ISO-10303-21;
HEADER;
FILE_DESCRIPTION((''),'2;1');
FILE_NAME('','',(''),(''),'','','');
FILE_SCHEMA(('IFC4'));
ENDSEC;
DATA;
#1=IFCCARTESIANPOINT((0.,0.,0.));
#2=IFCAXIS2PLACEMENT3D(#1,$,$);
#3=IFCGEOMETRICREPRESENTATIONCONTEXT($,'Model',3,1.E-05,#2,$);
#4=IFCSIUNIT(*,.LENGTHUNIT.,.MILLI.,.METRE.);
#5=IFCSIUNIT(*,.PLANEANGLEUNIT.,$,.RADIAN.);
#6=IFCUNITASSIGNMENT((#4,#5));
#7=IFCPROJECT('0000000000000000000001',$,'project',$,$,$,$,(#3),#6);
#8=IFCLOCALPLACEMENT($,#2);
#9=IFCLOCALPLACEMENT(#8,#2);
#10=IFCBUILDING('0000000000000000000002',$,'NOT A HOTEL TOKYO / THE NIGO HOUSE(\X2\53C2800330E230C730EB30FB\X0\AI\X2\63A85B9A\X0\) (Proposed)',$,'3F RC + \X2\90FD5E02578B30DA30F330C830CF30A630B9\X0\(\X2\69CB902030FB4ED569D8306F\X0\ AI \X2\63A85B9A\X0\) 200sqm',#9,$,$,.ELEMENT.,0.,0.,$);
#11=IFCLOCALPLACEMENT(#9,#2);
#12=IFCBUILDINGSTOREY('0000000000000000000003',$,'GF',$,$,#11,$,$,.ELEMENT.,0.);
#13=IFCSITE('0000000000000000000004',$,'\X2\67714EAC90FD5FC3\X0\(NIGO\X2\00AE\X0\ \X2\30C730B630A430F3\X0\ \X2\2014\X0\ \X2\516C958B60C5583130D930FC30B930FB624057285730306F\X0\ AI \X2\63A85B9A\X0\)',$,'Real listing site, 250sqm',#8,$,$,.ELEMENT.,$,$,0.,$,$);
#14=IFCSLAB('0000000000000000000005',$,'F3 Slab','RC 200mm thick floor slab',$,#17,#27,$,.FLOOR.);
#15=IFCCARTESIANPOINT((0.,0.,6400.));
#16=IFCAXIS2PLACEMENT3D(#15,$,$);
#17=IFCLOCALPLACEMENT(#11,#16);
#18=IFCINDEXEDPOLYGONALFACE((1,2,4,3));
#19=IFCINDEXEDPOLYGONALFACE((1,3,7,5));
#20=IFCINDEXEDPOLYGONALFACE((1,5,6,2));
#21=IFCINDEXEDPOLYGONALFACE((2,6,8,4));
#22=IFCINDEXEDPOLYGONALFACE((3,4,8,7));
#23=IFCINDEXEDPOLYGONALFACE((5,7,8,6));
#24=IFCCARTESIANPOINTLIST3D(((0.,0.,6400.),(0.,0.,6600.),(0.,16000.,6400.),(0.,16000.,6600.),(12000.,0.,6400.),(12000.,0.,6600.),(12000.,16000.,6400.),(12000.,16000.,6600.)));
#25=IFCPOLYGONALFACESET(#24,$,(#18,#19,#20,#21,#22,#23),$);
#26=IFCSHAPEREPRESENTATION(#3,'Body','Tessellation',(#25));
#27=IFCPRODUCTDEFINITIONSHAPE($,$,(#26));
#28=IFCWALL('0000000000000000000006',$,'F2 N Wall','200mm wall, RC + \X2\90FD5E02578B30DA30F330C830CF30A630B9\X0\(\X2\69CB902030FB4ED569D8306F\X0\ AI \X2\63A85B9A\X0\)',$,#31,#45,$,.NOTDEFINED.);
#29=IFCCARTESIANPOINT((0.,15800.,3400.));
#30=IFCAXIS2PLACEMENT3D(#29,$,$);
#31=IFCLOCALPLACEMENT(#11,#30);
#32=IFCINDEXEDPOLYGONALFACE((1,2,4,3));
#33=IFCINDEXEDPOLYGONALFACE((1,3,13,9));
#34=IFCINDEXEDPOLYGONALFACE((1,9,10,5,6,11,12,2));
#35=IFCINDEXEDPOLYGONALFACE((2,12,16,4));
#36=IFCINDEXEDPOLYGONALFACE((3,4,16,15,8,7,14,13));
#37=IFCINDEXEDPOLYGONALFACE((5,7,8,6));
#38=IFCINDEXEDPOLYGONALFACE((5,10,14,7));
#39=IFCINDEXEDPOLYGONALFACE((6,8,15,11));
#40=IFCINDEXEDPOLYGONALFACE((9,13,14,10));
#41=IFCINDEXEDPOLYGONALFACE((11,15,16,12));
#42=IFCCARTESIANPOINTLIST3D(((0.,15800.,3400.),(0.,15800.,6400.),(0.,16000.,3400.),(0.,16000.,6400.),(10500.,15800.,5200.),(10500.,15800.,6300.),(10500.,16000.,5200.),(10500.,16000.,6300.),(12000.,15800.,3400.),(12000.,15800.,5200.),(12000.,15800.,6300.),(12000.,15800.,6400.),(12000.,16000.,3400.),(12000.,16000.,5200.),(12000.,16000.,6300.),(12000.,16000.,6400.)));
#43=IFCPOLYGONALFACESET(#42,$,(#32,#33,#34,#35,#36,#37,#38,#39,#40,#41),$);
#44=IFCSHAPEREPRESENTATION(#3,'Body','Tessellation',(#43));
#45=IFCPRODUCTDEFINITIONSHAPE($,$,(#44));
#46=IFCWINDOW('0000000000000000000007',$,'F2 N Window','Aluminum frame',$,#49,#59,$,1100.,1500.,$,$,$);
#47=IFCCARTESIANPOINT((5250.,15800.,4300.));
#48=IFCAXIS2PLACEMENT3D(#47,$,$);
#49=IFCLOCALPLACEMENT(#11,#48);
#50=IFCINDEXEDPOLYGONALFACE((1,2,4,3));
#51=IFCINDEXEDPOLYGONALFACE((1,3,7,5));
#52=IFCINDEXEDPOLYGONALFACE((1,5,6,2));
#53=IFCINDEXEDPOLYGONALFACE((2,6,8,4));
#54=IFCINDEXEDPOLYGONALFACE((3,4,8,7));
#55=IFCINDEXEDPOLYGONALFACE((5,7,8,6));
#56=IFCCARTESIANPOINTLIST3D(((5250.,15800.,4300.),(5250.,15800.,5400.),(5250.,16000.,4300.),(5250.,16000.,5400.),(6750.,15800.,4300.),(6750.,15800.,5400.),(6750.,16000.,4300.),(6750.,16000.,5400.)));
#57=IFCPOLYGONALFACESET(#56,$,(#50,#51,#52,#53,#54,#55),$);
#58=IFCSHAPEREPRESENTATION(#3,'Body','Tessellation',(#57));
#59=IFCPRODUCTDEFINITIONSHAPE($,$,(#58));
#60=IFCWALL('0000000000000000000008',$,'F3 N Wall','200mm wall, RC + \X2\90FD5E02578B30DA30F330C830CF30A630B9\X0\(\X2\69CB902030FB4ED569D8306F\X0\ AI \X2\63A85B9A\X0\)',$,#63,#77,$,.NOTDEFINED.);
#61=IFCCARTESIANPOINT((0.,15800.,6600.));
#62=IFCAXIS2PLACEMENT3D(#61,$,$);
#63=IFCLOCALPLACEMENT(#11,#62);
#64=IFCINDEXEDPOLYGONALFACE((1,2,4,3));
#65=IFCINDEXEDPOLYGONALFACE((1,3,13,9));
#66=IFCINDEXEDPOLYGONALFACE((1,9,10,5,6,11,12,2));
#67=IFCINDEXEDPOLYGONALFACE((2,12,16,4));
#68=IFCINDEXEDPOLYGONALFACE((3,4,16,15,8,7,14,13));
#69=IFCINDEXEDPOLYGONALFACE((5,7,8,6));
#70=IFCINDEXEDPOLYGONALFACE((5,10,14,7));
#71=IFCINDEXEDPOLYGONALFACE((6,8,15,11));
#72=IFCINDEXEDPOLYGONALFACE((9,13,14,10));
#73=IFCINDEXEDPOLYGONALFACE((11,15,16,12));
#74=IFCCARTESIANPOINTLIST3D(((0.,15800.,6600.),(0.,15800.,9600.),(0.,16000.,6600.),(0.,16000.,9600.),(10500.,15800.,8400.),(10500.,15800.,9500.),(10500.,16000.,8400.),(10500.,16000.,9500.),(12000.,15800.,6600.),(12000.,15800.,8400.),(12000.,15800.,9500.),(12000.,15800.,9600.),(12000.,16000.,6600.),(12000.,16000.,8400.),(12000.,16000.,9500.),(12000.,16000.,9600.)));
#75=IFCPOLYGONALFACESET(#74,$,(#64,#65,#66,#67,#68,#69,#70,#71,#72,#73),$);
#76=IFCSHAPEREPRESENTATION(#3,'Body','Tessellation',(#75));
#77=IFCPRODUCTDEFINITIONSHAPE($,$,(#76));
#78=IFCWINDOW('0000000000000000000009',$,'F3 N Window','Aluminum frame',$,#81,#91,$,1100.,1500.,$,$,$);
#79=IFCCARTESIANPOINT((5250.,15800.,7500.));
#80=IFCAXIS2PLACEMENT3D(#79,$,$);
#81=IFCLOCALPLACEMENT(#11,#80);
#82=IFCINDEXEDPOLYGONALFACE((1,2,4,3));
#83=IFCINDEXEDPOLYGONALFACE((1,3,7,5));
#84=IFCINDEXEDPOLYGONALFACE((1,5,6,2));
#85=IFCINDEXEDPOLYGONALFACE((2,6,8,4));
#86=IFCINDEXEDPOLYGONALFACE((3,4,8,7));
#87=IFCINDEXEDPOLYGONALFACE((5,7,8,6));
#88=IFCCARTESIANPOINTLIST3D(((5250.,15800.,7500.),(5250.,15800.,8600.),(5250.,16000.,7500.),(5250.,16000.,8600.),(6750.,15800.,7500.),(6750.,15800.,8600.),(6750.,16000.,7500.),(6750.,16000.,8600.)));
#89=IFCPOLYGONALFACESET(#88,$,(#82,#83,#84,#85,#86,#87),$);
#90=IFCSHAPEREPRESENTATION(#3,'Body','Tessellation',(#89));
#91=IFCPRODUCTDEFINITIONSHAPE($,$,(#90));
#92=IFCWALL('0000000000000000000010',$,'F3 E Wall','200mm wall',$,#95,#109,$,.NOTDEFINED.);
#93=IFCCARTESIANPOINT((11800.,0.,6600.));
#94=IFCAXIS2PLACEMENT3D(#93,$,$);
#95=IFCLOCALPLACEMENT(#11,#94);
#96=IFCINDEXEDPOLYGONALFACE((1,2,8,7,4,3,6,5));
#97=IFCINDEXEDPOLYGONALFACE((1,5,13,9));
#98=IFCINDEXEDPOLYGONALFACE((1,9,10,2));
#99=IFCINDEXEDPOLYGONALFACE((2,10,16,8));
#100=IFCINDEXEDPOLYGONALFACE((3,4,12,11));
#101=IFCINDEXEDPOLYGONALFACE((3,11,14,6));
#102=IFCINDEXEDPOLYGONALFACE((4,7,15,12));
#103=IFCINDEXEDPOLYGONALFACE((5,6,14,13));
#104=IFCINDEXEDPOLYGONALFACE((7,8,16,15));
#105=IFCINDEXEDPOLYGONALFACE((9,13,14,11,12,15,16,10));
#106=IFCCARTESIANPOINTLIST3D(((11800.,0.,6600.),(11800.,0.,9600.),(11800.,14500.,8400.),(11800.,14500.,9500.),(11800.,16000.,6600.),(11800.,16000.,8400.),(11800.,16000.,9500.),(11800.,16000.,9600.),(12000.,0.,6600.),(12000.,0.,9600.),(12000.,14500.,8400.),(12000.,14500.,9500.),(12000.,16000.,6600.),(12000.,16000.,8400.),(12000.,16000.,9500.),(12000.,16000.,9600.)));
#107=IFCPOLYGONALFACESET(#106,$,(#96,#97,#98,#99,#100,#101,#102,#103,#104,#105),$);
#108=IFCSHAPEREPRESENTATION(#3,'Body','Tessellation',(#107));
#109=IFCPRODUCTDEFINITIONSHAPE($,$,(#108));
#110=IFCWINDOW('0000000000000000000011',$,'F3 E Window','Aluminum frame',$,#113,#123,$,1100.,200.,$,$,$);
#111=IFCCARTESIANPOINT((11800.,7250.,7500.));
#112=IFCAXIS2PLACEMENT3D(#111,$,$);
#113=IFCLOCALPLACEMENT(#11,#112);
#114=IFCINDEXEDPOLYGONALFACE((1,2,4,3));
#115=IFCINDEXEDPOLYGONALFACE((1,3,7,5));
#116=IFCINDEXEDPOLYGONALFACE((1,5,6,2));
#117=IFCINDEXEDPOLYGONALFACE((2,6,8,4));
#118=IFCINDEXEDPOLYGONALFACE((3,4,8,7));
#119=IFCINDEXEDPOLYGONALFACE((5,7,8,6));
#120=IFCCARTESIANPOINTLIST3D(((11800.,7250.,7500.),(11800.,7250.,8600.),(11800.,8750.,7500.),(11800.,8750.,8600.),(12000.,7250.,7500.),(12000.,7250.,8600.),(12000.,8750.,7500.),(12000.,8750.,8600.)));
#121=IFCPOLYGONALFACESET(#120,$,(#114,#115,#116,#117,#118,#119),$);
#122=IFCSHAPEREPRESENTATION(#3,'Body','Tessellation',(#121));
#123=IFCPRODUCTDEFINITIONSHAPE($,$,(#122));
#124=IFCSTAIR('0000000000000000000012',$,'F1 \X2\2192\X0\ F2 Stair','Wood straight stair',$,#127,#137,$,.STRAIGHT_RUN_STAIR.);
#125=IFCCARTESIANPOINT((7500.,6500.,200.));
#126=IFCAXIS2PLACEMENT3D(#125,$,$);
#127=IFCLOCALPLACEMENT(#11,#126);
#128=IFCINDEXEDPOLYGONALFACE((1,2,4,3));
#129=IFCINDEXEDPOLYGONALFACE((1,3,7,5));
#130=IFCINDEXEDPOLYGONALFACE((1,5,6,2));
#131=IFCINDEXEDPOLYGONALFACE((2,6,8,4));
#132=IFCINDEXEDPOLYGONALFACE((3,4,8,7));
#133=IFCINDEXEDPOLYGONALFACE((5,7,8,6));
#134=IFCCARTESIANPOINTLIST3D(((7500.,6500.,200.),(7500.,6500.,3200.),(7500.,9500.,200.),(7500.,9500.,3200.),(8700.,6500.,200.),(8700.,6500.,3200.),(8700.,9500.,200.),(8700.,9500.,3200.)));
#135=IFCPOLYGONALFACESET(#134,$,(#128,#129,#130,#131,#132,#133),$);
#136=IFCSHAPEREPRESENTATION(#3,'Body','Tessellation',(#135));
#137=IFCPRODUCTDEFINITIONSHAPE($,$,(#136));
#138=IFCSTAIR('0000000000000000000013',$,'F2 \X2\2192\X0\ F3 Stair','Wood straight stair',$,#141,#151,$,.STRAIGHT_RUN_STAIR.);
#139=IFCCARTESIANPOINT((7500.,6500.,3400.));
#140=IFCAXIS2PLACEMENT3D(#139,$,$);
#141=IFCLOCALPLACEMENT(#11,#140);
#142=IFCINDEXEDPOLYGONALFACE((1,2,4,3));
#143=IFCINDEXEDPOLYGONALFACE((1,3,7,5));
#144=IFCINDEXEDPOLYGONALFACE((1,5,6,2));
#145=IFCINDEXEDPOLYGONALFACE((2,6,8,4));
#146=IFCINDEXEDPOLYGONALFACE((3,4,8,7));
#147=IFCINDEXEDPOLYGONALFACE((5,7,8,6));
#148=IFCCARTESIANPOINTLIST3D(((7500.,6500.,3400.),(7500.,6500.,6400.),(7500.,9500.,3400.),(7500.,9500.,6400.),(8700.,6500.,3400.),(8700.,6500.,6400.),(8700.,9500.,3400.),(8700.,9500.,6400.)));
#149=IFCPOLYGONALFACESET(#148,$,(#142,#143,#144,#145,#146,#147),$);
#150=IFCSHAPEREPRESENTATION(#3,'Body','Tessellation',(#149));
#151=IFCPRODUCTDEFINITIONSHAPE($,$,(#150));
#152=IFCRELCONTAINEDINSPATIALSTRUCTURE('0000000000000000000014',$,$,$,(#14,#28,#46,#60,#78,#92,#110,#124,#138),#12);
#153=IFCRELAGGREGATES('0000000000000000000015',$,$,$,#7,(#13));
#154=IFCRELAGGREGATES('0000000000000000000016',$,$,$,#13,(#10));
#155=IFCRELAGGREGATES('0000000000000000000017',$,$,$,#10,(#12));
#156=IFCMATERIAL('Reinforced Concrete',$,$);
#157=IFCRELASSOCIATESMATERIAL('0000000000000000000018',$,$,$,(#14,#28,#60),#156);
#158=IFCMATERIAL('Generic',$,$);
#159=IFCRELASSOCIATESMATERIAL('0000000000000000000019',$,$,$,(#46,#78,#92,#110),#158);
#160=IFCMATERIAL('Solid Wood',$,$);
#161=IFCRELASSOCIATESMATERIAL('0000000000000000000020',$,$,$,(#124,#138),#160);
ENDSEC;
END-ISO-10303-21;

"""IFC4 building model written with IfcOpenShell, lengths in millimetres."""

from ifc_helpers import new_model, si_unit, frame, frame_2d, origin, place, context, project, spatial, rectangle, extrude, material, element, fill, save


model = new_model("IFC4")

# Units and contexts
model_context = context("Model", 3, precision=1e-05, world=origin())
ifc_project = project(units=[si_unit("LENGTHUNIT", "METRE", prefix="MILLI"), si_unit("PLANEANGLEUNIT", "RADIAN")], contexts=[model_context])

# Site, building, storey
site_placement = place(None, origin())
site = spatial("IfcSite", under=ifc_project, at=site_placement, Name="東京都心(NIGO® デザイン — 公開情報ベース・所在地は AI 推定)", ObjectType="Real listing site, 250sqm", CompositionType="ELEMENT", RefElevation=0.0)
building_placement = place(site_placement, origin())
building = spatial("IfcBuilding", under=site, at=building_placement, Name="NOT A HOTEL TOKYO / THE NIGO HOUSE(参考モデル・AI推定) (Proposed)", ObjectType="3F RC + 都市型ペントハウス(構造・仕様は AI 推定) 200sqm", CompositionType="ELEMENT", ElevationOfRefHeight=0.0, ElevationOfTerrain=0.0)
storey_placement = place(building_placement, origin())
storey = spatial("IfcBuildingStorey", under=building, at=storey_placement, Name="GF", CompositionType="ELEMENT", Elevation=0.0)

# Slab
ifc_material_1 = material(Name="Reinforced Concrete")
slab_placement = place(storey_placement, frame((0.0, 0.0, 6400.0)))
element("IfcSlab", 1, at=slab_placement, inside=storey, material=ifc_material_1, Name="F3 Slab", Description="RC 200mm thick floor slab", PredefinedType="FLOOR", context=model_context, shape_type="SweptSolid", body=[
    extrude(rectangle(XDim=12000.0, YDim=16000.0, at=frame_2d((6000.0, 8000.0))), frame((0.0, 0.0, 6400.0)), (0.0, 0.0, 1.0), 200.0),
])

# Walls, openings, windows
ifc_material_2 = material(Name="Generic")
wall_1_placement = place(storey_placement, frame((0.0, 15800.0, 3400.0)))
wall_1 = element("IfcWall", 2, at=wall_1_placement, inside=storey, material=ifc_material_1, Name="F2 N Wall", Description="200mm wall, RC + 都市型ペントハウス(構造・仕様は AI 推定)", PredefinedType="NOTDEFINED", context=model_context, shape_type="SweptSolid", body=[
    extrude(rectangle(XDim=12000.0, YDim=200.0, at=frame_2d((6000.0, 100.0))), frame((0.0, 15800.0, 3400.0)), (0.0, 0.0, 1.0), 3000.0),
])
opening_1_placement = place(storey_placement, frame((5250.0, 15800.0, 4300.0)))
opening_1 = element("IfcOpeningElement", 3, at=opening_1_placement, cuts=wall_1, PredefinedType="NOTDEFINED", context=model_context, shape_type="SweptSolid", body=[
    extrude(rectangle(XDim=1500.0, YDim=200.0, at=frame_2d((750.0, 100.0))), frame((5250.0, 15800.0, 4300.0)), (0.0, 0.0, 1.0), 1100.0),
])
window_1_placement = place(storey_placement, frame((5250.0, 15800.0, 4300.0)))
window_1 = element("IfcWindow", 4, at=window_1_placement, inside=storey, material=ifc_material_2, Name="F2 N Window", Description="Aluminum frame", OverallHeight=1100.0, OverallWidth=1500.0, context=model_context, shape_type="SweptSolid", body=[
    extrude(rectangle(XDim=1500.0, YDim=200.0, at=frame_2d((750.0, 100.0))), frame((5250.0, 15800.0, 4300.0)), (0.0, 0.0, 1.0), 1100.0),
])
fill(opening_1, window_1)
wall_2_placement = place(storey_placement, frame((0.0, 15800.0, 6600.0)))
wall_2 = element("IfcWall", 5, at=wall_2_placement, inside=storey, material=ifc_material_1, Name="F3 N Wall", Description="200mm wall, RC + 都市型ペントハウス(構造・仕様は AI 推定)", PredefinedType="NOTDEFINED", context=model_context, shape_type="SweptSolid", body=[
    extrude(rectangle(XDim=12000.0, YDim=200.0, at=frame_2d((6000.0, 100.0))), frame((0.0, 15800.0, 6600.0)), (0.0, 0.0, 1.0), 3000.0),
])
opening_2_placement = place(storey_placement, frame((5250.0, 15800.0, 7500.0)))
opening_2 = element("IfcOpeningElement", 6, at=opening_2_placement, cuts=wall_2, PredefinedType="NOTDEFINED", context=model_context, shape_type="SweptSolid", body=[
    extrude(rectangle(XDim=1500.0, YDim=200.0, at=frame_2d((750.0, 100.0))), frame((5250.0, 15800.0, 7500.0)), (0.0, 0.0, 1.0), 1100.0),
])
window_2_placement = place(storey_placement, frame((5250.0, 15800.0, 7500.0)))
window_2 = element("IfcWindow", 7, at=window_2_placement, inside=storey, material=ifc_material_2, Name="F3 N Window", Description="Aluminum frame", OverallHeight=1100.0, OverallWidth=1500.0, context=model_context, shape_type="SweptSolid", body=[
    extrude(rectangle(XDim=1500.0, YDim=200.0, at=frame_2d((750.0, 100.0))), frame((5250.0, 15800.0, 7500.0)), (0.0, 0.0, 1.0), 1100.0),
])
fill(opening_2, window_2)
wall_3_placement = place(storey_placement, frame((11800.0, 0.0, 6600.0)))
wall_3 = element("IfcWall", 8, at=wall_3_placement, inside=storey, material=ifc_material_2, Name="F3 E Wall", Description="200mm wall", PredefinedType="NOTDEFINED", context=model_context, shape_type="SweptSolid", body=[
    extrude(rectangle(XDim=200.0, YDim=16000.0, at=frame_2d((100.0, 8000.0))), frame((11800.0, 0.0, 6600.0)), (0.0, 0.0, 1.0), 3000.0),
])
opening_3_placement = place(storey_placement, frame((11800.0, 7250.0, 7500.0)))
opening_3 = element("IfcOpeningElement", 9, at=opening_3_placement, cuts=wall_3, PredefinedType="NOTDEFINED", context=model_context, shape_type="SweptSolid", body=[
    extrude(rectangle(XDim=200.0, YDim=1500.0, at=frame_2d((100.0, 750.0))), frame((11800.0, 7250.0, 7500.0)), (0.0, 0.0, 1.0), 1100.0),
])
window_3_placement = place(storey_placement, frame((11800.0, 7250.0, 7500.0)))
window_3 = element("IfcWindow", 10, at=window_3_placement, inside=storey, material=ifc_material_2, Name="F3 E Window", Description="Aluminum frame", OverallHeight=1100.0, OverallWidth=200.0, context=model_context, shape_type="SweptSolid", body=[
    extrude(rectangle(XDim=200.0, YDim=1500.0, at=frame_2d((100.0, 750.0))), frame((11800.0, 7250.0, 7500.0)), (0.0, 0.0, 1.0), 1100.0),
])
fill(opening_3, window_3)

# Stairs
ifc_material_3 = material(Name="Solid Wood")
stair_1_placement = place(storey_placement, frame((7500.0, 6500.0, 200.0)))
element("IfcStair", 11, at=stair_1_placement, inside=storey, material=ifc_material_3, Name="F1 → F2 Stair", Description="Wood straight stair", PredefinedType="STRAIGHT_RUN_STAIR", context=model_context, shape_type="SweptSolid", body=[
    extrude(rectangle(XDim=1200.0, YDim=3000.0, at=frame_2d((600.0, 1500.0))), frame((7500.0, 6500.0, 200.0)), (0.0, 0.0, 1.0), 3000.0),
])
stair_2_placement = place(storey_placement, frame((7500.0, 6500.0, 3400.0)))
element("IfcStair", 12, at=stair_2_placement, inside=storey, material=ifc_material_3, Name="F2 → F3 Stair", Description="Wood straight stair", PredefinedType="STRAIGHT_RUN_STAIR", context=model_context, shape_type="SweptSolid", body=[
    extrude(rectangle(XDim=1200.0, YDim=3000.0, at=frame_2d((600.0, 1500.0))), frame((7500.0, 6500.0, 3400.0)), (0.0, 0.0, 1.0), 3000.0),
])

save(model, "model.ifc")
